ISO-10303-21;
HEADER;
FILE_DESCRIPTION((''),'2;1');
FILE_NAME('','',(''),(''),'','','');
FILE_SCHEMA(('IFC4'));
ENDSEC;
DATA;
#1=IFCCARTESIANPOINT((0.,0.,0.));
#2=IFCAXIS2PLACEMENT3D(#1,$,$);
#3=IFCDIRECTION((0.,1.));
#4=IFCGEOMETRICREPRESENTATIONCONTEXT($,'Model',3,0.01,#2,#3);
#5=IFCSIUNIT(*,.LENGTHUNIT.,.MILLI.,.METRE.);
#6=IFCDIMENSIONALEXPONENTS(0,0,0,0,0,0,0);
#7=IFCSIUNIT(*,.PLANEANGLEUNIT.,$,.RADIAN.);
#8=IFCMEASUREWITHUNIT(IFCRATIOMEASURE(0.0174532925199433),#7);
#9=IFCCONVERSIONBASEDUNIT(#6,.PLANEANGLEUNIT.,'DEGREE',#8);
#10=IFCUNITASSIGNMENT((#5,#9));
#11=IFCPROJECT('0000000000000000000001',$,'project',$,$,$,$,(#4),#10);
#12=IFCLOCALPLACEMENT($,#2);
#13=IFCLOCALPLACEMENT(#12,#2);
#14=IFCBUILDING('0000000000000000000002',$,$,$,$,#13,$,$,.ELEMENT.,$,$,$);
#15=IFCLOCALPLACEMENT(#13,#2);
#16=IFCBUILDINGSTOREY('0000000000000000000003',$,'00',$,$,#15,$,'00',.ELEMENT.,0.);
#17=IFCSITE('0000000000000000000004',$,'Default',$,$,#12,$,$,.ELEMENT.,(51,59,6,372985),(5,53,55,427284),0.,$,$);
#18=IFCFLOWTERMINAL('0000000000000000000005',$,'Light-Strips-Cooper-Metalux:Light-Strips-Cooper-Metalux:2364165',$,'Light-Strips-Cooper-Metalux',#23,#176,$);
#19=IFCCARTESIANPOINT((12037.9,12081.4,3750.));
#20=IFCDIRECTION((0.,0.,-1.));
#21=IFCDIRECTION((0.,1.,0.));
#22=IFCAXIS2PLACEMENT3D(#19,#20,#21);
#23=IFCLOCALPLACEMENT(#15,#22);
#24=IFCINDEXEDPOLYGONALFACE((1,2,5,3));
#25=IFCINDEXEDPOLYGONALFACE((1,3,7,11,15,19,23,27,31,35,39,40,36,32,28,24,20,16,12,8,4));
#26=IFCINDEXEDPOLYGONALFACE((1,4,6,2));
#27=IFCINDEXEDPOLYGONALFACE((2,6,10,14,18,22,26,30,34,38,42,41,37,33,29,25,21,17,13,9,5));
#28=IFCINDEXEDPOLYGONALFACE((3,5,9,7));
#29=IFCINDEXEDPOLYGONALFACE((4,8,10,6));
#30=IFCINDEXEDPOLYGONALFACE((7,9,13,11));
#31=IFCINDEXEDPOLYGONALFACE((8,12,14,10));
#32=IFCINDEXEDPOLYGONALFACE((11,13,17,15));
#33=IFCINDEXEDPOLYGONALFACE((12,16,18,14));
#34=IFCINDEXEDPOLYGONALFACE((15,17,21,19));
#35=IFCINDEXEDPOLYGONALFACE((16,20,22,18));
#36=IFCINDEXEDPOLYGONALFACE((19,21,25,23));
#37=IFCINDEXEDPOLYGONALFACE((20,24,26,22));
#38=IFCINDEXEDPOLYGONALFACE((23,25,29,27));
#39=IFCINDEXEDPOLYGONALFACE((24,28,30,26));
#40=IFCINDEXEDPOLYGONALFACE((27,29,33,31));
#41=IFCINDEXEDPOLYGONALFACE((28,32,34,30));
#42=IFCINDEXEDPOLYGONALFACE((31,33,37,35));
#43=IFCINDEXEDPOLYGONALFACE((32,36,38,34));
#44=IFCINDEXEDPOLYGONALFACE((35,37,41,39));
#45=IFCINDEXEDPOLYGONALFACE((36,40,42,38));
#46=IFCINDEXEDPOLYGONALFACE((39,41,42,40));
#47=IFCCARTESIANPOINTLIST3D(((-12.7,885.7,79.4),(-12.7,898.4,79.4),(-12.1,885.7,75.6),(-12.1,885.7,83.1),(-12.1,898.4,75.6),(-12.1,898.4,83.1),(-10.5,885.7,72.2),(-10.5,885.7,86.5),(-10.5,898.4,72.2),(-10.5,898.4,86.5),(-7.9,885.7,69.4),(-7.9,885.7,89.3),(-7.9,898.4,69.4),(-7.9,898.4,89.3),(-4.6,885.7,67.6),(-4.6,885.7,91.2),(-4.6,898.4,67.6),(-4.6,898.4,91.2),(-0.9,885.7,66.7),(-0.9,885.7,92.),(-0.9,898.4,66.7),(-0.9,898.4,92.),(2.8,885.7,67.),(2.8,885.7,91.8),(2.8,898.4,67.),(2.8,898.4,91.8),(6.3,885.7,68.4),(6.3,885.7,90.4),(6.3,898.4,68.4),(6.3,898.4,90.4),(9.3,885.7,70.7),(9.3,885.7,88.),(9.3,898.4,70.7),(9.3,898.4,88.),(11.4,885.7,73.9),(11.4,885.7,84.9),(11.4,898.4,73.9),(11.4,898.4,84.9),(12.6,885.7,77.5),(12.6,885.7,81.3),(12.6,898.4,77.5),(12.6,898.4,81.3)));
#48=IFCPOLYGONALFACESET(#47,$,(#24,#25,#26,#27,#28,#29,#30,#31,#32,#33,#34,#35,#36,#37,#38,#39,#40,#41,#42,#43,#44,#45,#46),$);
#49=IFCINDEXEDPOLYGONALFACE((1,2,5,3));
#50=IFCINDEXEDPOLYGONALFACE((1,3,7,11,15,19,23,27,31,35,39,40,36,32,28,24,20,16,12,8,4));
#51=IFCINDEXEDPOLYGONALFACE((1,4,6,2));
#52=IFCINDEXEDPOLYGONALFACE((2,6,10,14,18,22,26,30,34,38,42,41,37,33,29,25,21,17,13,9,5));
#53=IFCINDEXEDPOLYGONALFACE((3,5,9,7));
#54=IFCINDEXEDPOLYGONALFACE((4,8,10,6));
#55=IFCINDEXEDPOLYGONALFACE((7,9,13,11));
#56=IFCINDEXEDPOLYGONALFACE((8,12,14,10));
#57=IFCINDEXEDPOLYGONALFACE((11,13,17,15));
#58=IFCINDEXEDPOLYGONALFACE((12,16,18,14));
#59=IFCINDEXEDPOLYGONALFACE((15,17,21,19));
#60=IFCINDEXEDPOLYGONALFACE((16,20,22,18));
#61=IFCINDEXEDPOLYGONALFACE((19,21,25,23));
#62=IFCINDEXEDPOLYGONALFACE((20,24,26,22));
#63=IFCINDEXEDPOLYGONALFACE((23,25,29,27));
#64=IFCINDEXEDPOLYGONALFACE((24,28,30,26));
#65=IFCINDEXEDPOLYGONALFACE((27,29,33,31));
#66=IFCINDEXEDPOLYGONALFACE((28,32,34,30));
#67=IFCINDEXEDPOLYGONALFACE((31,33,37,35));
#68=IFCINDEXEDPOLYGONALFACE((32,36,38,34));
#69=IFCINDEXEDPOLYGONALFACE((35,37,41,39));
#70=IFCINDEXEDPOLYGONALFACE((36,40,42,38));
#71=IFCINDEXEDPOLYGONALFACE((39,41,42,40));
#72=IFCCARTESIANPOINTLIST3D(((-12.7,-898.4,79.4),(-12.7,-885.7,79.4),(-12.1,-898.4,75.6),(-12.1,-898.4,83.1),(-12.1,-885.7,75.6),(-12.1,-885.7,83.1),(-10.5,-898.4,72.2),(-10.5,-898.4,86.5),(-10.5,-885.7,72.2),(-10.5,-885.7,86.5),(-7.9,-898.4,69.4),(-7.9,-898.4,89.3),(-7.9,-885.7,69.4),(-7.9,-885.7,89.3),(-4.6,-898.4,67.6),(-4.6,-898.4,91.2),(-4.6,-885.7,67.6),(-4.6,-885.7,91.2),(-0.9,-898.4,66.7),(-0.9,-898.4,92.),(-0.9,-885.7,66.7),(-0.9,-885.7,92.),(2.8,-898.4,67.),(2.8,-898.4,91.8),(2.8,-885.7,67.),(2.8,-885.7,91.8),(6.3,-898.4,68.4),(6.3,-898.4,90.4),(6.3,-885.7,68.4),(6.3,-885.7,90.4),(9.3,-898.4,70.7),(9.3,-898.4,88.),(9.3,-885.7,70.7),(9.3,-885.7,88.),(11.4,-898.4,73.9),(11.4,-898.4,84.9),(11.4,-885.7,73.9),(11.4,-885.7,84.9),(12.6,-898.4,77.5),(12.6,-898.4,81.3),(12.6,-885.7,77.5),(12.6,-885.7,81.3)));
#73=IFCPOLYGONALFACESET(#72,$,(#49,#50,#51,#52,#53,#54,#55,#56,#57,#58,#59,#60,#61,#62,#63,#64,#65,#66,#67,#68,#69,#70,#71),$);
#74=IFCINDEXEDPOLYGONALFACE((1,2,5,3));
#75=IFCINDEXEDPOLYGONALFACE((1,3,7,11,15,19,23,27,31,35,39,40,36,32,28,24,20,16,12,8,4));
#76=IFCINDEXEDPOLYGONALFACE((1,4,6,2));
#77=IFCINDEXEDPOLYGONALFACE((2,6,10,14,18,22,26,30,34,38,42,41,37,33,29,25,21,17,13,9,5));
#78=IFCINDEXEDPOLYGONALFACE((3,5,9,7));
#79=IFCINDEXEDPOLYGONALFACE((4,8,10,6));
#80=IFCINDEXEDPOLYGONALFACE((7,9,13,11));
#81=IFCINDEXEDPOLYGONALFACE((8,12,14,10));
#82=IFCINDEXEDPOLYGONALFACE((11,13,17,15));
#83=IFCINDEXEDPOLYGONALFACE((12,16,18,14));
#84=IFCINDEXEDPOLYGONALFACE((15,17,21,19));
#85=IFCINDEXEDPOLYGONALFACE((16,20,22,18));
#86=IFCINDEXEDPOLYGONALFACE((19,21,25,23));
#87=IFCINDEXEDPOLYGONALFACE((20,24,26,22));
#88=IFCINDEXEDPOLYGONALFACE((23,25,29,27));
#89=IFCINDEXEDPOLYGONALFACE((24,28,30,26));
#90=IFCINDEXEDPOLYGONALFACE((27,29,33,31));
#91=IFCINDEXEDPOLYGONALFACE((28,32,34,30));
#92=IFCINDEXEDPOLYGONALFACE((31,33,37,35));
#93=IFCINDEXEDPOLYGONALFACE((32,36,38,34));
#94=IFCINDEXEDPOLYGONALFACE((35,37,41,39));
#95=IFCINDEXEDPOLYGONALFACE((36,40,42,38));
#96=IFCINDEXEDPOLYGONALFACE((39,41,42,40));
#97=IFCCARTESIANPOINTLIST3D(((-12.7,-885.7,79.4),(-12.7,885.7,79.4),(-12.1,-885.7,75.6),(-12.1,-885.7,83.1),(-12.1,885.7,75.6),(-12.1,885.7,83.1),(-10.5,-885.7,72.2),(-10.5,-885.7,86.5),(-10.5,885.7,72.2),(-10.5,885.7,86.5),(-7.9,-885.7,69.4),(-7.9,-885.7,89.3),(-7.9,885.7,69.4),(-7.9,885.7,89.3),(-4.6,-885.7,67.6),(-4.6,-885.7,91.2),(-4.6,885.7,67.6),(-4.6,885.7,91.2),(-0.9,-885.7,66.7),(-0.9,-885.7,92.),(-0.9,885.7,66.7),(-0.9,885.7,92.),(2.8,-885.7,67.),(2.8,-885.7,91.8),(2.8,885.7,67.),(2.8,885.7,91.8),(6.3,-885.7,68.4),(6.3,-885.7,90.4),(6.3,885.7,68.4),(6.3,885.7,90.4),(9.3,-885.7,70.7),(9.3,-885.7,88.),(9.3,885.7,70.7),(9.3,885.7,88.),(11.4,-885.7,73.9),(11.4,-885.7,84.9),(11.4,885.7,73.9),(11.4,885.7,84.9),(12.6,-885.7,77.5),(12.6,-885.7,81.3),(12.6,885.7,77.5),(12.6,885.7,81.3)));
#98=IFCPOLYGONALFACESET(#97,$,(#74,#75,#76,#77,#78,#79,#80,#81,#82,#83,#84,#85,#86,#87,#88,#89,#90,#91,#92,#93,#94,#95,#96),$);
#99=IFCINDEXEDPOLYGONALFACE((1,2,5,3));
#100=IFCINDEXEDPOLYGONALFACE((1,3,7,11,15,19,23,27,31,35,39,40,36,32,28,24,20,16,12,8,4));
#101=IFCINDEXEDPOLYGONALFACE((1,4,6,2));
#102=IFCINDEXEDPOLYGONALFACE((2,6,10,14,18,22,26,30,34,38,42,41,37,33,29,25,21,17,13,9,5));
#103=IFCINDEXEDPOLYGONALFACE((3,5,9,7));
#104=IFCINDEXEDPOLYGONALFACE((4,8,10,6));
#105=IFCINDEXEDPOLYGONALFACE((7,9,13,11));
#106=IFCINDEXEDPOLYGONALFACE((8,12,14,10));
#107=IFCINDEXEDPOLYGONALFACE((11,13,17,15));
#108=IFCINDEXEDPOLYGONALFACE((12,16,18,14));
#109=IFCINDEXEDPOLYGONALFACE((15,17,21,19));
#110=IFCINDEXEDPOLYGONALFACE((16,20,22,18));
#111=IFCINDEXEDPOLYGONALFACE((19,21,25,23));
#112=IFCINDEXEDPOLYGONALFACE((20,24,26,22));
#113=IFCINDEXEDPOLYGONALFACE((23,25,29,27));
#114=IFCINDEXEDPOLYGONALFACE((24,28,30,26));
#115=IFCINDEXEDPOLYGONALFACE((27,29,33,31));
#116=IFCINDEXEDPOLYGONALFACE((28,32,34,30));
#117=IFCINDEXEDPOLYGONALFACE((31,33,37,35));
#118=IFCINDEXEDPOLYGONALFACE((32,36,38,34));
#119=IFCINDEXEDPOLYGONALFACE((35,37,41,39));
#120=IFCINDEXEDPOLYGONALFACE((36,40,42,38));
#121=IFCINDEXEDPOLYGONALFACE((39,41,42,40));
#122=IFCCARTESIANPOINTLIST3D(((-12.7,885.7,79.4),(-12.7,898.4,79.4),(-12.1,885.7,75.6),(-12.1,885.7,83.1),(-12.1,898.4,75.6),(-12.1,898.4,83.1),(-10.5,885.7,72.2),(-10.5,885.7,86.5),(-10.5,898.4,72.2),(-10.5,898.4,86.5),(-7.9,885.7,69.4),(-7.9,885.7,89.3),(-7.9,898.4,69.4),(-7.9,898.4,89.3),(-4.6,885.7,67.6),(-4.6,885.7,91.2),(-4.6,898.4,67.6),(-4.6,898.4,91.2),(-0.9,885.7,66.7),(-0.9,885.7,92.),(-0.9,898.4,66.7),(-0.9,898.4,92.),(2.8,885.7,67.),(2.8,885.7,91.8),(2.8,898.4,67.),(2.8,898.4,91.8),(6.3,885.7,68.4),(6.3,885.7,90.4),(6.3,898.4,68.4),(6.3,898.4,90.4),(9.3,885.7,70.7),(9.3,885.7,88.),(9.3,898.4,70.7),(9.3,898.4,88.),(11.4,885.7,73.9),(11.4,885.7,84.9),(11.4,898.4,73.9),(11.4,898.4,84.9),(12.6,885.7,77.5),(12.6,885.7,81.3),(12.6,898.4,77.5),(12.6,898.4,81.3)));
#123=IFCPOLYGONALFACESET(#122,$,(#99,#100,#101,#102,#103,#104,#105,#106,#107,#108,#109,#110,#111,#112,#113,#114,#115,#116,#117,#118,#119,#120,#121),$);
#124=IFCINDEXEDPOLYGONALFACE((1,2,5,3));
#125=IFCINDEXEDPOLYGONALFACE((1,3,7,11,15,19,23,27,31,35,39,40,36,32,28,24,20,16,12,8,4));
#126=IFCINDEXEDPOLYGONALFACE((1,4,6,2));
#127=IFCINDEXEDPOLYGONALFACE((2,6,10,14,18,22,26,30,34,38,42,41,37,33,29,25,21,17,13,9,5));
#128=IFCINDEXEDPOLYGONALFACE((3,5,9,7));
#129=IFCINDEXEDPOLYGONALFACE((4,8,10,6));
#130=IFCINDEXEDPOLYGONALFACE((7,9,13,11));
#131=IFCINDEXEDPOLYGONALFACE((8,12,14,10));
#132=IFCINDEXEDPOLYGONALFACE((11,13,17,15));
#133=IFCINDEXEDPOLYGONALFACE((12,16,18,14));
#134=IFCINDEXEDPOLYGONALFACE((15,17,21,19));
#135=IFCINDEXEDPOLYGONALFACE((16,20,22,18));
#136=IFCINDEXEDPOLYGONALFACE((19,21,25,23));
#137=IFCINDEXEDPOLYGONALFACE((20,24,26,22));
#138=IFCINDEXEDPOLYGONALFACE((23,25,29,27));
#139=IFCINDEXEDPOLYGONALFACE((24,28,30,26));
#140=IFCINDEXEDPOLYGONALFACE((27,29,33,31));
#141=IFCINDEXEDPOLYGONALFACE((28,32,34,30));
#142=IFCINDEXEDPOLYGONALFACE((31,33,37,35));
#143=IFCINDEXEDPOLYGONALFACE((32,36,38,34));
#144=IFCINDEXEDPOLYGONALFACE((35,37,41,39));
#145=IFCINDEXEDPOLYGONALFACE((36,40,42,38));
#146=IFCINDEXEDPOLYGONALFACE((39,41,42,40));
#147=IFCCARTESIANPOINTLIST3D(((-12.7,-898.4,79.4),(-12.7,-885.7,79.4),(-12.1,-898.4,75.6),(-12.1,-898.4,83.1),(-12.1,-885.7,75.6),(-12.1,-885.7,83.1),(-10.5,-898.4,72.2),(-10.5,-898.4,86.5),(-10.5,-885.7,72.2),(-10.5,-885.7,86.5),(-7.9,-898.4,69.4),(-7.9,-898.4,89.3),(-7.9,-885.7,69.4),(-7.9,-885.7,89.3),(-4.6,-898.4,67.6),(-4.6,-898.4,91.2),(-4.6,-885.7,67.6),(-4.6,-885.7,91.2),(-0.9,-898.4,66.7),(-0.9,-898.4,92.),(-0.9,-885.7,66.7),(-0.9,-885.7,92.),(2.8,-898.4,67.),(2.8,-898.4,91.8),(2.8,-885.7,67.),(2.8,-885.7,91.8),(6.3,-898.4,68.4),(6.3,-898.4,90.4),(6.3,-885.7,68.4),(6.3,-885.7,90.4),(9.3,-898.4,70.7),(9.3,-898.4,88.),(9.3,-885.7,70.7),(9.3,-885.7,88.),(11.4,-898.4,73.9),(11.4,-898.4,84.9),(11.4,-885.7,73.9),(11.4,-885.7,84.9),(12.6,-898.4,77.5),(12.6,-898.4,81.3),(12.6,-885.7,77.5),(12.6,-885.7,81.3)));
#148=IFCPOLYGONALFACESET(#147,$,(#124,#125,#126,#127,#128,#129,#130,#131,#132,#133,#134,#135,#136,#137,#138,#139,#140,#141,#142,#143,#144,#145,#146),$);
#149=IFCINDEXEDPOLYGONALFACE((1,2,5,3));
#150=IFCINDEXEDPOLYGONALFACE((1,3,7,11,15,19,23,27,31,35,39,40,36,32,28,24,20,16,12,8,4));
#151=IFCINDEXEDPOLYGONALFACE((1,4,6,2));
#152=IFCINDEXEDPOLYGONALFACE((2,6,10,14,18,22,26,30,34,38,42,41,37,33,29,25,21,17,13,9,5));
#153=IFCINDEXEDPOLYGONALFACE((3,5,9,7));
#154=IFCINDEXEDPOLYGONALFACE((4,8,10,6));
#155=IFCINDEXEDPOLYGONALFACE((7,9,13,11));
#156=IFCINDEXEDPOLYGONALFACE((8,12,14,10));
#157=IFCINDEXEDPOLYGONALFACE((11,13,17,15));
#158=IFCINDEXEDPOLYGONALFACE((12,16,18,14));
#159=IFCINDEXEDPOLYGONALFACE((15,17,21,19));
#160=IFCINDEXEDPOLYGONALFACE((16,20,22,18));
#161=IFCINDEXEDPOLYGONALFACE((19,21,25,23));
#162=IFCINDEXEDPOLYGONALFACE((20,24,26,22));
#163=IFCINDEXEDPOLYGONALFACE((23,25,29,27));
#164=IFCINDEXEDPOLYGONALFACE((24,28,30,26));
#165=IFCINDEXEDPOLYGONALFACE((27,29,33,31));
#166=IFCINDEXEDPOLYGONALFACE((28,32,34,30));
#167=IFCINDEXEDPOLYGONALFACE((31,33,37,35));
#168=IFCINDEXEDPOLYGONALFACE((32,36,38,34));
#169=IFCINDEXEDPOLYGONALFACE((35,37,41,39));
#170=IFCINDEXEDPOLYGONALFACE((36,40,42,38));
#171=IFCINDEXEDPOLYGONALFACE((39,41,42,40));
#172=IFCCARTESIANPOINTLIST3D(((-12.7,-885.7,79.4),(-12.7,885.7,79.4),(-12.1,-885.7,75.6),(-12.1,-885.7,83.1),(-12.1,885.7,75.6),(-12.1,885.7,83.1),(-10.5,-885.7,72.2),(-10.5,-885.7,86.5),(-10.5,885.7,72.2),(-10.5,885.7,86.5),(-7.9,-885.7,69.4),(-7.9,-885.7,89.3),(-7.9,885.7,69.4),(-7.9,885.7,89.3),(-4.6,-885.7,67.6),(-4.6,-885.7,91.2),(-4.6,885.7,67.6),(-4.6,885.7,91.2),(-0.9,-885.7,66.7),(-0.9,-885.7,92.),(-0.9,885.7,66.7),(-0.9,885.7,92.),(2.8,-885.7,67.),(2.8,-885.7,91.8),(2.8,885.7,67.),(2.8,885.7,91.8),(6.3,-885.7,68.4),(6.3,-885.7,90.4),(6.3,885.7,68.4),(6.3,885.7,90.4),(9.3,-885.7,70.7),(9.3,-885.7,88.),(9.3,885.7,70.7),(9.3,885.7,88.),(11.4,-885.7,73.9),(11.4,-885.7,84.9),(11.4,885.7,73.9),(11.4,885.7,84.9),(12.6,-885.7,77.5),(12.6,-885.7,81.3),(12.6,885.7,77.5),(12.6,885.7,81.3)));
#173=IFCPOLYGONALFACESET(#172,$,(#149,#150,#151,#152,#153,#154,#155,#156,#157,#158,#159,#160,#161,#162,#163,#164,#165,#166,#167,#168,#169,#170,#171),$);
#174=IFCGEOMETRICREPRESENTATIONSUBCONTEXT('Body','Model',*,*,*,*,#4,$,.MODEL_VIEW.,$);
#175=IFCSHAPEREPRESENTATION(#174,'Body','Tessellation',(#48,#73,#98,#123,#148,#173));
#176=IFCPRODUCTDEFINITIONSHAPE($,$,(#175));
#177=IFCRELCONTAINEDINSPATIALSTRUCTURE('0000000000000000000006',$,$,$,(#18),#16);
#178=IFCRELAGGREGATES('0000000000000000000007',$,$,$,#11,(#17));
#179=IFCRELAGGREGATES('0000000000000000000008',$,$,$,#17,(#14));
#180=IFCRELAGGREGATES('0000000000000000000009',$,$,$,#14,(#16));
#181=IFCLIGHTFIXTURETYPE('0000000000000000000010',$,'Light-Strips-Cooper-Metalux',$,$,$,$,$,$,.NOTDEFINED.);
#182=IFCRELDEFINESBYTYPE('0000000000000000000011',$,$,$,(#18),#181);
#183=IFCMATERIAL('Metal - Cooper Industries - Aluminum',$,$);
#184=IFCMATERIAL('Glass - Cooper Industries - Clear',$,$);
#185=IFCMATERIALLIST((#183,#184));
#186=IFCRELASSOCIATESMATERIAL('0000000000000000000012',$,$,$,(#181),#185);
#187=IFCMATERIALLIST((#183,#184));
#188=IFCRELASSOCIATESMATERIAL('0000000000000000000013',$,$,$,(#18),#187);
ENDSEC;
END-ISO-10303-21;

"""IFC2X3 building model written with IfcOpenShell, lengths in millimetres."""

from ifc_helpers import new_model, entity, si_unit, converted_unit, direction, frame, frame_2d, origin, place, context, subcontext, project, spatial, circle, extrude, source, transform, mapped, material, material_list, type_object, type_shapes, element, save


model = new_model("IFC2X3")

# Units and contexts
model_context = context("Model", 3, precision=0.01, world=origin(), true_north=direction((0.0, 1.0)))
body_context = subcontext(model_context, "Body", "Model", "MODEL_VIEW")
ifc_project = project(units=[si_unit("LENGTHUNIT", "METRE", prefix="MILLI"), converted_unit("PLANEANGLEUNIT", "DEGREE", entity("IfcRatioMeasure", 0.0174532925199433), si_unit("PLANEANGLEUNIT", "RADIAN"), dimensions=[0, 0, 0, 0, 0, 0, 0])], contexts=[model_context])

# Site, building, storey
site_placement = place(None, origin())
site = spatial("IfcSite", under=ifc_project, at=site_placement, Name="Default", CompositionType="ELEMENT", RefLatitude=(51, 59, 6, 372985), RefLongitude=(5, 53, 55, 427284), RefElevation=0.0)
building_placement = place(site_placement, origin())
building = spatial("IfcBuilding", under=site, at=building_placement, CompositionType="ELEMENT")
storey_placement = place(building_placement, origin())
storey = spatial("IfcBuildingStorey", under=building, at=storey_placement, Name="00", LongName="00", CompositionType="ELEMENT", Elevation=0.0)

# Flow terminal
ifc_material_1 = material(Name="Metal - Cooper Industries - Aluminum")
ifc_material_2 = material(Name="Glass - Cooper Industries - Clear")
ifc_material_list_1 = material_list([ifc_material_1, ifc_material_2])
ifc_material_list_2 = material_list([ifc_material_1, ifc_material_2])
light_fixture_type = type_object("IfcLightFixtureType", Name="Light-Strips-Cooper-Metalux", PredefinedType="NOTDEFINED", material=ifc_material_list_2)
shared_shape_1 = source(origin(), body_context, "Body", "SweptSolid", [
    extrude(circle(Radius=12.7, at=frame_2d((0.0, 0.0), x_axis=(1.0, 0.0))), frame((0.0, 885.7, 79.4), z_axis=(0.0, 1.0, 0.0), x_axis=(-1.0, 0.0, 0.0)), (0.0, 0.0, 1.0), 12.7),
    extrude(circle(Radius=12.7, at=frame_2d((0.0, 0.0), x_axis=(1.0, 0.0))), frame((0.0, -898.4, 79.4), z_axis=(0.0, 1.0, 0.0), x_axis=(-1.0, 0.0, 0.0)), (0.0, 0.0, 1.0), 12.7),
    extrude(circle(Radius=12.7, at=frame_2d((0.0, 0.0), x_axis=(1.0, 0.0))), frame((0.0, -885.7, 79.4), z_axis=(0.0, 1.0, 0.0), x_axis=(-1.0, 0.0, 0.0)), (0.0, 0.0, 1.0), 1771.4),
    extrude(circle(Radius=12.7, at=frame_2d((0.0, 0.0), x_axis=(1.0, 0.0))), frame((0.0, 885.7, 79.4), z_axis=(0.0, 1.0, 0.0), x_axis=(-1.0, 0.0, 0.0)), (0.0, 0.0, 1.0), 12.7),
    extrude(circle(Radius=12.7, at=frame_2d((0.0, 0.0), x_axis=(1.0, 0.0))), frame((0.0, -898.4, 79.4), z_axis=(0.0, 1.0, 0.0), x_axis=(-1.0, 0.0, 0.0)), (0.0, 0.0, 1.0), 12.7),
    extrude(circle(Radius=12.7, at=frame_2d((0.0, 0.0), x_axis=(1.0, 0.0))), frame((0.0, -885.7, 79.4), z_axis=(0.0, 1.0, 0.0), x_axis=(-1.0, 0.0, 0.0)), (0.0, 0.0, 1.0), 1771.4),
])
type_shapes(light_fixture_type, [shared_shape_1])
flow_terminal_1_placement = place(storey_placement, frame((12037.9, 12081.4, 3750.0), z_axis=(0.0, 0.0, -1.0), x_axis=(0.0, 1.0, 0.0)))
element("IfcFlowTerminal", 1, at=flow_terminal_1_placement, inside=storey, type_object=light_fixture_type, material=ifc_material_list_1, Name="Light-Strips-Cooper-Metalux:Light-Strips-Cooper-Metalux:2364165", ObjectType="Light-Strips-Cooper-Metalux", context=body_context, shape_type="MappedRepresentation", body=[
    mapped(shared_shape_1, transform((0.0, 0.0, 0.0), scale=1.0)),
])

save(model, "model.ifc")
